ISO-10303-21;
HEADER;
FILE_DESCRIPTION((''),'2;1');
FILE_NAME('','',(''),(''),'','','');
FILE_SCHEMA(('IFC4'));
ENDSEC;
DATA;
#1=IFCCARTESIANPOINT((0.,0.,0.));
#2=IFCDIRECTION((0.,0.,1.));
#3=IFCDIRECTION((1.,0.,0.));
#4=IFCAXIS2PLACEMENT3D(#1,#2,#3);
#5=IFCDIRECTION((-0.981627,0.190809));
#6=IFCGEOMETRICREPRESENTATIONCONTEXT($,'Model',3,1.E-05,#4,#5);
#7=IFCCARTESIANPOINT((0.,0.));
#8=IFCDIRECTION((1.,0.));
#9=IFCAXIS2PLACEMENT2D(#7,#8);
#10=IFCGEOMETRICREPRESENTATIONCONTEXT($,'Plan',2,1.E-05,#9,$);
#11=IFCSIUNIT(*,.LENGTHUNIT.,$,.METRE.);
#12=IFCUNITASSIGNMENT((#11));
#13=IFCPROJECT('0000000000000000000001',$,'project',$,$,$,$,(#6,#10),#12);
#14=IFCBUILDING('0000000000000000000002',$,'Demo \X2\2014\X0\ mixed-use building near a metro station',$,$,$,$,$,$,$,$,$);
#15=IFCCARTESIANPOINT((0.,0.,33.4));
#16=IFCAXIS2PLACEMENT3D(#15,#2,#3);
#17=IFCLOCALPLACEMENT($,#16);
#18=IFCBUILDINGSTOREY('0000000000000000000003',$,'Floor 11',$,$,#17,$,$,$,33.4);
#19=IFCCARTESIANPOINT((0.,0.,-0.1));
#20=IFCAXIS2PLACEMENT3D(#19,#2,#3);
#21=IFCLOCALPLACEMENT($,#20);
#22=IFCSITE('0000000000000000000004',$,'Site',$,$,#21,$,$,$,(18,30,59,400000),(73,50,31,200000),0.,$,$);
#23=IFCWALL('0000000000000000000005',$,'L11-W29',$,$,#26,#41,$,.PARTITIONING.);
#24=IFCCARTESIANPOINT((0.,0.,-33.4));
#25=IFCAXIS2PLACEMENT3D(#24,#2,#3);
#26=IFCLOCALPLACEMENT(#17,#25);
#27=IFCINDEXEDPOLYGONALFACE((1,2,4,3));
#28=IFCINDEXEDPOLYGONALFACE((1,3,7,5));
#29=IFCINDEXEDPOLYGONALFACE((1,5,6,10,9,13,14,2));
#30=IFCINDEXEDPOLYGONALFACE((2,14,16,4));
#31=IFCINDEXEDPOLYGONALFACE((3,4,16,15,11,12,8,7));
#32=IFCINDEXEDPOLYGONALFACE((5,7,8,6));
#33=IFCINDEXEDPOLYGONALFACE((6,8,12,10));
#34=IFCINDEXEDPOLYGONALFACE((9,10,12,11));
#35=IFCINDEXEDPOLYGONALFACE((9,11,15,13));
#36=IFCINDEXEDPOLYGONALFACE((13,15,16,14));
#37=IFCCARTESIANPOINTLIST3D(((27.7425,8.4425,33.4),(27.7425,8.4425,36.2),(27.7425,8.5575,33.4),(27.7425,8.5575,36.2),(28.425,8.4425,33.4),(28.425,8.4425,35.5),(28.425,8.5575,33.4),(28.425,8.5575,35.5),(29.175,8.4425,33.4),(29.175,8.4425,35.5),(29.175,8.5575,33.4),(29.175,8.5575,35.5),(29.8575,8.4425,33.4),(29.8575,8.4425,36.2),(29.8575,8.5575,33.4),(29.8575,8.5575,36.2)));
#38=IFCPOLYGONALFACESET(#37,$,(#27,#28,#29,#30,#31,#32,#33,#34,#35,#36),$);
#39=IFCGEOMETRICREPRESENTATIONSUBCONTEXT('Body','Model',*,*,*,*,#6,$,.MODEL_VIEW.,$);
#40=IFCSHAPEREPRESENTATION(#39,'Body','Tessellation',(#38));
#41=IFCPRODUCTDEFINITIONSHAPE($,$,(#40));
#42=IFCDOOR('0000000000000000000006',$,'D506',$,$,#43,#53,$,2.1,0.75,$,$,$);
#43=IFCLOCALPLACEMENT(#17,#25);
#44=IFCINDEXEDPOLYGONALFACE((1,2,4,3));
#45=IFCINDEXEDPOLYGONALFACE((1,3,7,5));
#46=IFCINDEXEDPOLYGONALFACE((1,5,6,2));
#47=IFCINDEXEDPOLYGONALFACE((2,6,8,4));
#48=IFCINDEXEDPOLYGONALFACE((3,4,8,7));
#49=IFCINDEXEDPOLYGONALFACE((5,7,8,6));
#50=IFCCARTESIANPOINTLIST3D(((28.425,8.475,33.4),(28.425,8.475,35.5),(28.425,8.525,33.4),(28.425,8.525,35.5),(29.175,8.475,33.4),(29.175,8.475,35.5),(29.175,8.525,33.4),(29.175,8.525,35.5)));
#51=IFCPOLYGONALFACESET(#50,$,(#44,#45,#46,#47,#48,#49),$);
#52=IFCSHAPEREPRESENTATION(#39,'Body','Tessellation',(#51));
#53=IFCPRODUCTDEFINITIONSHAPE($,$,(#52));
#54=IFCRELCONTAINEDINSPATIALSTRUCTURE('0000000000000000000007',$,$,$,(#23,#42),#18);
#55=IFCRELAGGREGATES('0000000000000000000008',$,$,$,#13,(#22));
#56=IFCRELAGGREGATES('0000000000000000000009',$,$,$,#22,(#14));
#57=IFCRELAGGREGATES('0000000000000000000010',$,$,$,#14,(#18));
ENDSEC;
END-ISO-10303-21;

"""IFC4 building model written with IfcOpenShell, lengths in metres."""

from ifc_helpers import new_model, si_unit, direction, frame, origin_with_axes, origin_2d_with_axis, place, context, subcontext, project, spatial, line, indexed_curve, outline, extrude, element, fill, save


model = new_model("IFC4")

# Units and contexts
model_context = context("Model", 3, precision=1e-05, world=origin_with_axes(), true_north=direction((-0.981627, 0.190809)))
plan_context = context("Plan", 2, precision=1e-05, world=origin_2d_with_axis())
body_context = subcontext(model_context, "Body", "Model", "MODEL_VIEW")
ifc_project = project(units=[si_unit("LENGTHUNIT", "METRE")], contexts=[model_context, plan_context])

# Site, building, storey
site_placement = place(None, frame((0.0, 0.0, -0.1), z_axis=(0.0, 0.0, 1.0), x_axis=(1.0, 0.0, 0.0)))
site = spatial("IfcSite", under=ifc_project, at=site_placement, Name="Site", RefLatitude=(18, 30, 59, 400000), RefLongitude=(73, 50, 31, 200000), RefElevation=0.0)
building = spatial("IfcBuilding", under=site, Name="Demo — mixed-use building near a metro station")
storey_placement = place(None, frame((0.0, 0.0, 33.4), z_axis=(0.0, 0.0, 1.0), x_axis=(1.0, 0.0, 0.0)))
storey = spatial("IfcBuildingStorey", under=building, at=storey_placement, Name="Floor 11", Elevation=33.4)

# Wall, opening, door
wall_1_placement = place(storey_placement, frame((0.0, 0.0, -33.4), z_axis=(0.0, 0.0, 1.0), x_axis=(1.0, 0.0, 0.0)))
wall_1 = element("IfcWall", 1, at=wall_1_placement, inside=storey, Name="L11-W29", PredefinedType="PARTITIONING", context=body_context, shape_type="SweptSolid", body=[
    extrude(outline(indexed_curve([(29.8575, 8.4425), (27.7425, 8.4425), (27.7425, 8.5575), (29.8575, 8.5575)], segments=[line(1, 2, 3, 4, 1)])), frame((0.0, 0.0, 33.4), z_axis=(0.0, 0.0, 1.0), x_axis=(1.0, 0.0, 0.0)), (0.0, 0.0, 1.0), 2.8),
])
opening_1_placement = place(wall_1_placement, origin_with_axes())
opening_1 = element("IfcOpeningElement", 2, at=opening_1_placement, cuts=wall_1, context=body_context, shape_type="SweptSolid", body=[
    extrude(outline(indexed_curve([(29.175, 8.3925), (28.425, 8.3925), (28.425, 8.6075), (29.175, 8.6075)], segments=[line(1, 2, 3, 4, 1)])), frame((0.0, 0.0, 33.4), z_axis=(0.0, 0.0, 1.0), x_axis=(1.0, 0.0, 0.0)), (0.0, 0.0, 1.0), 2.1),
])
door_1_placement = place(storey_placement, frame((0.0, 0.0, -33.4), z_axis=(0.0, 0.0, 1.0), x_axis=(1.0, 0.0, 0.0)))
door_1 = element("IfcDoor", 3, at=door_1_placement, inside=storey, Name="D506", OverallHeight=2.1, OverallWidth=0.75, context=body_context, shape_type="SweptSolid", body=[
    extrude(outline(indexed_curve([(29.175, 8.475), (28.425, 8.475), (28.425, 8.525), (29.175, 8.525)], segments=[line(1, 2, 3, 4, 1)])), frame((0.0, 0.0, 33.4), z_axis=(0.0, 0.0, 1.0), x_axis=(1.0, 0.0, 0.0)), (0.0, 0.0, 1.0), 2.1),
])
fill(opening_1, door_1)

save(model, "model.ifc")
